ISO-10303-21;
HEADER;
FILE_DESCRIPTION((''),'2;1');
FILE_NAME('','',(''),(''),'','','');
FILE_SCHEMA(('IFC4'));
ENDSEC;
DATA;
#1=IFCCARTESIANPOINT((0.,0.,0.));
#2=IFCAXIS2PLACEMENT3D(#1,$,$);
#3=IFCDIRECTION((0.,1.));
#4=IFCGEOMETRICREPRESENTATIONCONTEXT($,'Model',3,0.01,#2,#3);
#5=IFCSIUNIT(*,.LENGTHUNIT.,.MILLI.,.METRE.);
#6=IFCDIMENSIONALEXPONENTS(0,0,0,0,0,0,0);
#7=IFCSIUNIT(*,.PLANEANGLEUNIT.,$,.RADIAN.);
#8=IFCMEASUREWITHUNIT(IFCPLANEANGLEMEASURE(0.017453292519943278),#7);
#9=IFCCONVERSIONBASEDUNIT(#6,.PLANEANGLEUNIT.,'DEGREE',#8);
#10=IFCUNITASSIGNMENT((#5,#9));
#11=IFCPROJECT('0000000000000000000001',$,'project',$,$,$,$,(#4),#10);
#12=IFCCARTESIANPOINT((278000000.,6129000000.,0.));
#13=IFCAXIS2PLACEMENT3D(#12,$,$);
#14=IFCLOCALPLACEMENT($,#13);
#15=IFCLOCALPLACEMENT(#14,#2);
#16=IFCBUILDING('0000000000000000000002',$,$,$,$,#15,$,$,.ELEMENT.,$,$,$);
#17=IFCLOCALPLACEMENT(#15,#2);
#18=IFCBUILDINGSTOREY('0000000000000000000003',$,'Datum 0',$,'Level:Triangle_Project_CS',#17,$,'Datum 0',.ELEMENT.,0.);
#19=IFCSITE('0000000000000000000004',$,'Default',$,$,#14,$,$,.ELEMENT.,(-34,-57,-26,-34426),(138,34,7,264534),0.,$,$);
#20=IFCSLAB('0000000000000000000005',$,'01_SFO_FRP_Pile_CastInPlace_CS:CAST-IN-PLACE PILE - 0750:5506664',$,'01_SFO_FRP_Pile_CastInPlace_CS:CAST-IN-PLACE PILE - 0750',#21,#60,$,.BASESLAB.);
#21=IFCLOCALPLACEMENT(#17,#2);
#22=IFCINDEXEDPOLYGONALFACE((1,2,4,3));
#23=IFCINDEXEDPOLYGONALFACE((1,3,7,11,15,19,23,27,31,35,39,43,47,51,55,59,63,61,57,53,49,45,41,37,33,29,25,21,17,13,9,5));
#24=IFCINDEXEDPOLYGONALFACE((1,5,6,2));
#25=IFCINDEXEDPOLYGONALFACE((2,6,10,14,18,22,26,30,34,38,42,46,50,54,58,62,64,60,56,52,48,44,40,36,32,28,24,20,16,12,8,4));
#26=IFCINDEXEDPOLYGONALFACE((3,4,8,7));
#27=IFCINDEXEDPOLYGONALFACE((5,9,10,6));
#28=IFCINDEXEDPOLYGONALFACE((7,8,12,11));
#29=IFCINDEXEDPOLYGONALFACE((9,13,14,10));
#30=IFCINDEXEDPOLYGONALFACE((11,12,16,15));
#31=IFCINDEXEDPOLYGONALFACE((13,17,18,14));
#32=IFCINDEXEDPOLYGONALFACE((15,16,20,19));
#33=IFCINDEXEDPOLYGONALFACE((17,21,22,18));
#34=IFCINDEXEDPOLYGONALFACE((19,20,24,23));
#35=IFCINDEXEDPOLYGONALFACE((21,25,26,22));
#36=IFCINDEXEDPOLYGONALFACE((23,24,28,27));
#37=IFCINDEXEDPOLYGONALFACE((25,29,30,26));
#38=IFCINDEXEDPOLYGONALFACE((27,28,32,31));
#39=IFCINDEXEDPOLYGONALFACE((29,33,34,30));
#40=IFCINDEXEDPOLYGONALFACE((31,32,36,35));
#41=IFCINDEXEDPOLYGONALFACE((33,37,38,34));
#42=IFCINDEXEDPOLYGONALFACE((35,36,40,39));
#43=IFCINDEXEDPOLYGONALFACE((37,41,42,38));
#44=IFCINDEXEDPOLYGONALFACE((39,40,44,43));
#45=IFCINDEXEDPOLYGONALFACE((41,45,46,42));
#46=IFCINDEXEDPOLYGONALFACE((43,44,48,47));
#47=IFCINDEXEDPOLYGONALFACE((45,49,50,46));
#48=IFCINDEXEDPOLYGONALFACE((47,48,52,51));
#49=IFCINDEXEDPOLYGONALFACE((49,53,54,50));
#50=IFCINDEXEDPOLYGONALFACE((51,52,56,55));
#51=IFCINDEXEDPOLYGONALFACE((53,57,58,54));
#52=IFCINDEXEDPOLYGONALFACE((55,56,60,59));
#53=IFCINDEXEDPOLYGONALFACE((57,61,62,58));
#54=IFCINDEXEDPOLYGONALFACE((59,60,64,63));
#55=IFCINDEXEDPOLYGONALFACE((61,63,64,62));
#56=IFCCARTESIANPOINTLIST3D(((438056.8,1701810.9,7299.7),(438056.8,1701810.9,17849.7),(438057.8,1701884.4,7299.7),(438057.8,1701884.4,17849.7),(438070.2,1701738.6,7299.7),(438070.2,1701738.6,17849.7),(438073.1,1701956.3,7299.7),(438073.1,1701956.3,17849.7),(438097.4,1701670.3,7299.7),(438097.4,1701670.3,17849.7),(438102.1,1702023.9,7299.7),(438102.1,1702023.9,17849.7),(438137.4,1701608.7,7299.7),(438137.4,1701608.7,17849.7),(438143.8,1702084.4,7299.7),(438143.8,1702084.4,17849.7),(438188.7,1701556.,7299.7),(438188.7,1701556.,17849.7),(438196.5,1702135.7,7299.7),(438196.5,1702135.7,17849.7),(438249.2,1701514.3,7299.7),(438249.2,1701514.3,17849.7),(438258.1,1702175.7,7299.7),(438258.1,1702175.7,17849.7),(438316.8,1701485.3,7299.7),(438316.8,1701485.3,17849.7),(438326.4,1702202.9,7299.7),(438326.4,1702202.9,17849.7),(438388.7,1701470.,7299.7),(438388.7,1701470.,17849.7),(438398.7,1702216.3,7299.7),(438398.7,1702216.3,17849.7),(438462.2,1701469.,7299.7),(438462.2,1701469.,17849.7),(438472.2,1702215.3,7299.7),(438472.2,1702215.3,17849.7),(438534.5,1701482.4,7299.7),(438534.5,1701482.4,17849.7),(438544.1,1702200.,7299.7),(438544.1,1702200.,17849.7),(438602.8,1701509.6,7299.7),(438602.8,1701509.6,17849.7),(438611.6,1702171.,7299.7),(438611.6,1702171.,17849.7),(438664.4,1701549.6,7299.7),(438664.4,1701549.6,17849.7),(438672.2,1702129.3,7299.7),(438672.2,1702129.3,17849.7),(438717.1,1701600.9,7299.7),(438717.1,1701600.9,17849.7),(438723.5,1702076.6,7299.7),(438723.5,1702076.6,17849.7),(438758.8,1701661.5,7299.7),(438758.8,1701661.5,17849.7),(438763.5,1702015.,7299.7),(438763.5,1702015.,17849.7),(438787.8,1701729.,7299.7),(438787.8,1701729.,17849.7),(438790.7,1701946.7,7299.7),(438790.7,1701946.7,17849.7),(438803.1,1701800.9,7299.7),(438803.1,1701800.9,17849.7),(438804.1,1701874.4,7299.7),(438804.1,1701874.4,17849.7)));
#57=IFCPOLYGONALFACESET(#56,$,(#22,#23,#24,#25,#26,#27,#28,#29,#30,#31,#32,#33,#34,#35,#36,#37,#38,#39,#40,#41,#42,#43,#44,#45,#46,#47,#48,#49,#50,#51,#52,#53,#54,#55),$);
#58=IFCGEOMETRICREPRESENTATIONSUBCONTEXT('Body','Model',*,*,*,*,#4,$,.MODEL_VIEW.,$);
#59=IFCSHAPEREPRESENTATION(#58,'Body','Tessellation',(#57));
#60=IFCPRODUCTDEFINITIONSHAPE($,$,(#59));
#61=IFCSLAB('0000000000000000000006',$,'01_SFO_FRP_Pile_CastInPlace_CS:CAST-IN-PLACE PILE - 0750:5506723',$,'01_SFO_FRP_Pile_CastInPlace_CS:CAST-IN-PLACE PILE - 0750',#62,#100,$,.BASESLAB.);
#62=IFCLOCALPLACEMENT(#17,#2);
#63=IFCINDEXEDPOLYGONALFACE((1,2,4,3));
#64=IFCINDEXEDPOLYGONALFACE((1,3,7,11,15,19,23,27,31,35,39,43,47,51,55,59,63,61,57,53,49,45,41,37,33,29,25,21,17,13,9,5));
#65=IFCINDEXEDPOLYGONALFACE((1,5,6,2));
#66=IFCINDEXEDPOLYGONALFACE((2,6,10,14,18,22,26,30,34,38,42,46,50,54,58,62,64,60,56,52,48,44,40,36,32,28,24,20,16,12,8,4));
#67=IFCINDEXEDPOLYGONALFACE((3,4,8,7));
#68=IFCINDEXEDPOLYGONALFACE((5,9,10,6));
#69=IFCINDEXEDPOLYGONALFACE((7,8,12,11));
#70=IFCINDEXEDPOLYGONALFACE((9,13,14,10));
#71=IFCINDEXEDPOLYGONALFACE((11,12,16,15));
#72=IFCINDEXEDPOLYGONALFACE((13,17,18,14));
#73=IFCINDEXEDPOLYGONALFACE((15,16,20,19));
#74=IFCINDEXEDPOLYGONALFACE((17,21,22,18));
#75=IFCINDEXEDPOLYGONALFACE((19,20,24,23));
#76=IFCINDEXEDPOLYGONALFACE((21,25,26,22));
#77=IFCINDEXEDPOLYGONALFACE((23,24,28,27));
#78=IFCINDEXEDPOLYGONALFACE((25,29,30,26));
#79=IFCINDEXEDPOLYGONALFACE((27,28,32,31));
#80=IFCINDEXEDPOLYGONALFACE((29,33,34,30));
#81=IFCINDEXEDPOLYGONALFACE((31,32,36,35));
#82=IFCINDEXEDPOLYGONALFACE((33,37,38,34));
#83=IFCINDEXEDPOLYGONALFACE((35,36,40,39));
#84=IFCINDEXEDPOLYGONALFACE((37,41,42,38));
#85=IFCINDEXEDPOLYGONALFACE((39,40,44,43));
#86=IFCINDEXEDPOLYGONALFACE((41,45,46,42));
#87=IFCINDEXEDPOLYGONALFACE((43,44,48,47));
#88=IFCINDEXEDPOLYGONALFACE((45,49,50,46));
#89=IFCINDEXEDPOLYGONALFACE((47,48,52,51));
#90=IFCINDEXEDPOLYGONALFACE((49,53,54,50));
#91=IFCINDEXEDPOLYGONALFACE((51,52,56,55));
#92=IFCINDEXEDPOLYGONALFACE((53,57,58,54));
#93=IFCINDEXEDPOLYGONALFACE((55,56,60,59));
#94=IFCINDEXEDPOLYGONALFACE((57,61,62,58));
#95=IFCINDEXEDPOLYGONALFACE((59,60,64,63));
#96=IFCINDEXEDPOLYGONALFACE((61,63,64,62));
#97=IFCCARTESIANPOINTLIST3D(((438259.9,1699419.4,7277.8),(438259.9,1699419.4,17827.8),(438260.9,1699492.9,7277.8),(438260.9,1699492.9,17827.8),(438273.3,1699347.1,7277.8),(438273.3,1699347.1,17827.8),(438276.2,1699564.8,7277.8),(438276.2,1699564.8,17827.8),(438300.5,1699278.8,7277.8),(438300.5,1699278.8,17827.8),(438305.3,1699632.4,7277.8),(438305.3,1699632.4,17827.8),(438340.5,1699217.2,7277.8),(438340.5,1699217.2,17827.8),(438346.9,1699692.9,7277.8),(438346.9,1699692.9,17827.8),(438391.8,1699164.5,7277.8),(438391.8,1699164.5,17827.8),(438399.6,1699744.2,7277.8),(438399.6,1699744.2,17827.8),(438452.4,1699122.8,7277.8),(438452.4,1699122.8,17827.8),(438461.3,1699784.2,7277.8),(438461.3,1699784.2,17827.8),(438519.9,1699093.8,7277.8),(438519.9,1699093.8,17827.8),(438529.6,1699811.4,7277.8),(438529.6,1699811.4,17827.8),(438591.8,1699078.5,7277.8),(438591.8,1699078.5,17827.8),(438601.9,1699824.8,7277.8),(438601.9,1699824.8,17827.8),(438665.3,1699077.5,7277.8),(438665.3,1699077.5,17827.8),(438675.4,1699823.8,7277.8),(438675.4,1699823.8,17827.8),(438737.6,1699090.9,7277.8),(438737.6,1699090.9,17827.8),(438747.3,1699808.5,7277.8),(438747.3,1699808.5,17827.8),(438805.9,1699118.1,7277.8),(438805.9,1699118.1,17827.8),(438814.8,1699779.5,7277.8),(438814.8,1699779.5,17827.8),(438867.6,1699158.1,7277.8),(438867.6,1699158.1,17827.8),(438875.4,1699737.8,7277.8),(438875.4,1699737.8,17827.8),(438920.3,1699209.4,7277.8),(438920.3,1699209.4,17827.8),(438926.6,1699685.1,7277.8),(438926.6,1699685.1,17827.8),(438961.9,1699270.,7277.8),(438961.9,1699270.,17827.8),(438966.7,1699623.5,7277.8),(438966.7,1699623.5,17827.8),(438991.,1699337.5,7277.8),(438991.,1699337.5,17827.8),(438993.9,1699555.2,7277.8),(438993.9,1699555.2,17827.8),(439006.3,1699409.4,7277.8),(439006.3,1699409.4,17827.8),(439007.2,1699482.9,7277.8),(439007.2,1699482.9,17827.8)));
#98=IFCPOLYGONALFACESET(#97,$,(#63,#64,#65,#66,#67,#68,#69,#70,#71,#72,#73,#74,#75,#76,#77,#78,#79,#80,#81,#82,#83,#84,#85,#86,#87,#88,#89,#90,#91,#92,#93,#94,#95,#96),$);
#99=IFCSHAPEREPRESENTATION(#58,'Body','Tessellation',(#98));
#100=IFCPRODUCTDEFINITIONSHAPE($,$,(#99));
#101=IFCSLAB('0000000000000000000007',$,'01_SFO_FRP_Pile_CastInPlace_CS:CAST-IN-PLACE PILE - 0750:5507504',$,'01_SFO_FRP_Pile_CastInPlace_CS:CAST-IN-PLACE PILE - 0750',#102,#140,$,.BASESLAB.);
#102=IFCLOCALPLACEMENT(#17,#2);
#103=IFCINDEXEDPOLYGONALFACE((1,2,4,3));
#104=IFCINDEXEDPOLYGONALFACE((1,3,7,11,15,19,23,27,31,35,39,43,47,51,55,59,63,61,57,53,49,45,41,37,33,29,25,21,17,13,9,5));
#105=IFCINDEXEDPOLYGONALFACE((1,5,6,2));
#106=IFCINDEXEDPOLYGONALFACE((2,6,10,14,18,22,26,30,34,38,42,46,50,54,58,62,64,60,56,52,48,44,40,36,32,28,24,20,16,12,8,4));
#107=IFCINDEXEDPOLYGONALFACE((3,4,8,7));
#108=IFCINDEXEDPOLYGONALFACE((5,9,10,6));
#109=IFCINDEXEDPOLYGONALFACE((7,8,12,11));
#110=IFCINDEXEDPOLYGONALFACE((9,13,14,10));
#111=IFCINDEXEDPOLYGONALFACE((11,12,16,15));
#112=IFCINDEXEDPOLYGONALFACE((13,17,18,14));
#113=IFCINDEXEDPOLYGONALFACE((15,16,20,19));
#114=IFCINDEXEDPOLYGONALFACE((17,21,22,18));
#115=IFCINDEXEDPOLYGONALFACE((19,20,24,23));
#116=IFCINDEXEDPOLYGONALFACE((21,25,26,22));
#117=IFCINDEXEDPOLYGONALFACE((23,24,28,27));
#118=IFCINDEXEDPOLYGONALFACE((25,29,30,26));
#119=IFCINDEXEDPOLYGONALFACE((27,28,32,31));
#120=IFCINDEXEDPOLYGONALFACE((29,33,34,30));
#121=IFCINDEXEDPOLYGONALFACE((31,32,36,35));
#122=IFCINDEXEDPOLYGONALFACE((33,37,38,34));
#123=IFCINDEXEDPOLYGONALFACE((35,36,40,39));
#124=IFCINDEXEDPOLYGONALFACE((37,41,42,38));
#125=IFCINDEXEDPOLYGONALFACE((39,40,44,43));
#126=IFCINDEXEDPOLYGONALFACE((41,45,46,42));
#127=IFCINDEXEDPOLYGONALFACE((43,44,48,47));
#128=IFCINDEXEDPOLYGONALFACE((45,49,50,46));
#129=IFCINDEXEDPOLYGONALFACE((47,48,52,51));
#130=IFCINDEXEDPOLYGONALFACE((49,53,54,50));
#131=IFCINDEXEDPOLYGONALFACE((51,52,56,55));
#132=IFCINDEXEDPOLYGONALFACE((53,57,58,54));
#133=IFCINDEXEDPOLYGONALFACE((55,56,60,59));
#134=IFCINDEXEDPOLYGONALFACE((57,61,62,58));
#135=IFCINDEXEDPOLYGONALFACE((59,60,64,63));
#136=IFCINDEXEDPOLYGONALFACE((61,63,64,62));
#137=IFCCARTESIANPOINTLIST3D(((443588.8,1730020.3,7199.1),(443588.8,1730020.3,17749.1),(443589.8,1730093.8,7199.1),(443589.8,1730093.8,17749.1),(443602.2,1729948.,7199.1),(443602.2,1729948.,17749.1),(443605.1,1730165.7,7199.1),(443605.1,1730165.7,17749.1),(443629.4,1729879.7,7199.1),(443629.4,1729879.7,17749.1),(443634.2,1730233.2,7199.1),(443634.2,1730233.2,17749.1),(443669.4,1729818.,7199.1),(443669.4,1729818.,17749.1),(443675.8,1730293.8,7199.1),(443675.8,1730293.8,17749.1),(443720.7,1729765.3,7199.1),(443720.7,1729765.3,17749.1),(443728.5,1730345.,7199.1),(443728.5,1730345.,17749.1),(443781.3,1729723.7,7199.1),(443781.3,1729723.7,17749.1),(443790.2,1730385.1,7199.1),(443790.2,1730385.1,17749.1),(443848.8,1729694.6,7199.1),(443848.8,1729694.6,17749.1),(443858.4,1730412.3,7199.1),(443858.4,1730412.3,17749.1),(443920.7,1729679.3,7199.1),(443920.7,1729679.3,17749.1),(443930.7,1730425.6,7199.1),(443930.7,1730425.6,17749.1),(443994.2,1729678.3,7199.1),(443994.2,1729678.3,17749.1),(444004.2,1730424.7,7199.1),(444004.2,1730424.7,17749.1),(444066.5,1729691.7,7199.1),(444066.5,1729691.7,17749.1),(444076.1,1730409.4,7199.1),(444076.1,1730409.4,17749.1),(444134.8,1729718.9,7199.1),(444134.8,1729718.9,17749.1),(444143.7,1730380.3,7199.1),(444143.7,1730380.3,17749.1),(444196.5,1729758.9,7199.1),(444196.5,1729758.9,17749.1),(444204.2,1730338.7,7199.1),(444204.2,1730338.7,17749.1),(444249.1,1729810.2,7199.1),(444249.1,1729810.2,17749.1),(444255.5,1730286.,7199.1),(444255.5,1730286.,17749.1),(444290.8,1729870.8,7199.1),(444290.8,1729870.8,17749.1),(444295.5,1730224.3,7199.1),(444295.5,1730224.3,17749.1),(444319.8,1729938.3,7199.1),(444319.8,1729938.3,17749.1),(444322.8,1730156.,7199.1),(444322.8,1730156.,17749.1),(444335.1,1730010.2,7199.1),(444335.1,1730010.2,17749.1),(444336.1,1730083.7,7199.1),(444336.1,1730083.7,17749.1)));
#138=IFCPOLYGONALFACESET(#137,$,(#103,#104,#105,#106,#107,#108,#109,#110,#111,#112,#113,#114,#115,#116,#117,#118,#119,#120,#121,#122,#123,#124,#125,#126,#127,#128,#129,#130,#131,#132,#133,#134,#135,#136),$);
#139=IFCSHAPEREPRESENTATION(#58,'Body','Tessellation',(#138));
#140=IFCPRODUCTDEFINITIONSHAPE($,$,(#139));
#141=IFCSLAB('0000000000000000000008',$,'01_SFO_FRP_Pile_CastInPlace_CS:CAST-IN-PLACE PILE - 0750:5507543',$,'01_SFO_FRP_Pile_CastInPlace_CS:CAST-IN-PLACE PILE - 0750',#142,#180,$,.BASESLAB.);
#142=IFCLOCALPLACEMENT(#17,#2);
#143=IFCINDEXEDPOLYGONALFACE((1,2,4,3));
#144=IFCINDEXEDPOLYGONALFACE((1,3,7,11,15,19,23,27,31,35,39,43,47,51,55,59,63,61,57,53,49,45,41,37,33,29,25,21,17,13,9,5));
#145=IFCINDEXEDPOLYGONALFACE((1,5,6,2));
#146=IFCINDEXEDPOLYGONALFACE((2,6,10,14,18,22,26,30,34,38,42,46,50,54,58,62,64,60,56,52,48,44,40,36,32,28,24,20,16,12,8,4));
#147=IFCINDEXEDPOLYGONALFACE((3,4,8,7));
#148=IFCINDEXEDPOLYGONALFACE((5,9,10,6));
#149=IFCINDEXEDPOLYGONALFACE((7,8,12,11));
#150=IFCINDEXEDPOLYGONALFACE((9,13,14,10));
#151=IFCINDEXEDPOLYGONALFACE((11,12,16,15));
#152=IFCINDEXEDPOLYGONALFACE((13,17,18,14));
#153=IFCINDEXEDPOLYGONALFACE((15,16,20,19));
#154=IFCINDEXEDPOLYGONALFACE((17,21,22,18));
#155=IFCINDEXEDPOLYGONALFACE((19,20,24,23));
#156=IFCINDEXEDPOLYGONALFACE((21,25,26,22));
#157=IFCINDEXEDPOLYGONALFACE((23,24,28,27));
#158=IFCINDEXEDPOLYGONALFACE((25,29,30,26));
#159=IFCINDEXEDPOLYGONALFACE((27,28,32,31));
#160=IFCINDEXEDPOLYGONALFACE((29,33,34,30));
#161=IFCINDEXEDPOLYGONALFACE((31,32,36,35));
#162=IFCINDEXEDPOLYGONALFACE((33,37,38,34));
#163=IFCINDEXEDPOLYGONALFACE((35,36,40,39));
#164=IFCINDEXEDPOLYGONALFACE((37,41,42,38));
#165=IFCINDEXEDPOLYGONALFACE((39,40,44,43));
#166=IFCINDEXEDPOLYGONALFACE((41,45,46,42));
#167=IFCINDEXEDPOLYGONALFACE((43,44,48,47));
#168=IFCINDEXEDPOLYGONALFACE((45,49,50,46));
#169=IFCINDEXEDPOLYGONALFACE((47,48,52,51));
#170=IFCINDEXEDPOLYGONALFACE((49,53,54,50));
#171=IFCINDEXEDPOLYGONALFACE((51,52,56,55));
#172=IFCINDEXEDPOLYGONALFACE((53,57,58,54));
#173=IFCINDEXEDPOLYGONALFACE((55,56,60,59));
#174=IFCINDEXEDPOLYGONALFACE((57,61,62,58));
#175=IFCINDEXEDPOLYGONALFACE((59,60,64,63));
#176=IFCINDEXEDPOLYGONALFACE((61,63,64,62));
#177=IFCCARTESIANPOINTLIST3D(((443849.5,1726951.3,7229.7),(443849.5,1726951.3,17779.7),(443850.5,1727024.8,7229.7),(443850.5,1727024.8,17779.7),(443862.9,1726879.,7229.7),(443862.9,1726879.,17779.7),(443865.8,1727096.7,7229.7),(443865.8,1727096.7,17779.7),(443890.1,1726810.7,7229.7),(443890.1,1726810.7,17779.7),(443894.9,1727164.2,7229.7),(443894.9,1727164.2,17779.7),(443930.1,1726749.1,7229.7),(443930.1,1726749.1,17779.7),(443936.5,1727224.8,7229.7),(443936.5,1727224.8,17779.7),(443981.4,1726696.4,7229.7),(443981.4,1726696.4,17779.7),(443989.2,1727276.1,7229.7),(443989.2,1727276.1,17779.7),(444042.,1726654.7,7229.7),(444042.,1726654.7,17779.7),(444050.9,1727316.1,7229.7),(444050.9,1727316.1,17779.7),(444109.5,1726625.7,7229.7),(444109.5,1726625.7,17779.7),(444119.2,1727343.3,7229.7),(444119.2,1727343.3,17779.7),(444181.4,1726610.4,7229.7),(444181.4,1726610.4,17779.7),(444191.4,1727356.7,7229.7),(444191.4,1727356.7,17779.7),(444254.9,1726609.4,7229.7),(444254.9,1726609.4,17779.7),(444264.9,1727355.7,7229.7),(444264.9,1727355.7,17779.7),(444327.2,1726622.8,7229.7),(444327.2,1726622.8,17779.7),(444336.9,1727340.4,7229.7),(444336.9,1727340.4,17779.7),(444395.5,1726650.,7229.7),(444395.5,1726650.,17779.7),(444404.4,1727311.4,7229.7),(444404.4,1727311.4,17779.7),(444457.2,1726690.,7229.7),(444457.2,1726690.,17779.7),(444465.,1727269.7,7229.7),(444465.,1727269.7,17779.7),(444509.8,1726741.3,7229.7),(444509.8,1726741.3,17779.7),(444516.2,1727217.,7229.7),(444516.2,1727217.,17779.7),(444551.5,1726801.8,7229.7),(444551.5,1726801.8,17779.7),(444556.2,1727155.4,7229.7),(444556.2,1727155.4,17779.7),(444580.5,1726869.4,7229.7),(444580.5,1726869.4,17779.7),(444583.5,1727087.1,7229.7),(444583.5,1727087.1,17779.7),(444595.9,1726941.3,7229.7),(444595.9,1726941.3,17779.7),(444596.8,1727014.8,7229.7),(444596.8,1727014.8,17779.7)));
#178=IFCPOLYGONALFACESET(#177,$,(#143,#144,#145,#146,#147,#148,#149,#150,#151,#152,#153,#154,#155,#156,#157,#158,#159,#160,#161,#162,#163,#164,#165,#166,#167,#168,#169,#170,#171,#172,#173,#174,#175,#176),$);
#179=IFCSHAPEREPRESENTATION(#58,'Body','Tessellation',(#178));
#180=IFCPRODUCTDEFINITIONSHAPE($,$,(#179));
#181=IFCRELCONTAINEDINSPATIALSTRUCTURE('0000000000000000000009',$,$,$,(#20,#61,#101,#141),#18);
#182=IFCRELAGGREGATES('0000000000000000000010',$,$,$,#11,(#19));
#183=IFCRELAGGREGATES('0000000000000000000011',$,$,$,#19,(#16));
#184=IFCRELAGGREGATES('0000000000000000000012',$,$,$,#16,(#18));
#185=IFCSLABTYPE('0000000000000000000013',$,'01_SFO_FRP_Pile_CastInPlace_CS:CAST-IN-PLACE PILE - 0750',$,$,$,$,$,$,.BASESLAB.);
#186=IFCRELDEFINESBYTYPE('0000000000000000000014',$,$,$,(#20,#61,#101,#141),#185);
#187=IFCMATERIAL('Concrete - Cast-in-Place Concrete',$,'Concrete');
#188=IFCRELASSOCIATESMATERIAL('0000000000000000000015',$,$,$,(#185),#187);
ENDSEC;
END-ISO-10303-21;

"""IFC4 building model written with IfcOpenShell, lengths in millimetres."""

from ifc_helpers import new_model, entity, si_unit, converted_unit, direction, frame, origin, place, context, subcontext, project, spatial, arc, indexed_curve, outline, extrude, material, type_object, element, save


model = new_model("IFC4")

# Units and contexts
model_context = context("Model", 3, precision=0.01, world=origin(), true_north=direction((0.0, 1.0)))
body_context = subcontext(model_context, "Body", "Model", "MODEL_VIEW")
ifc_project = project(units=[si_unit("LENGTHUNIT", "METRE", prefix="MILLI"), converted_unit("PLANEANGLEUNIT", "DEGREE", entity("IfcPlaneAngleMeasure", 0.017453292519943278), si_unit("PLANEANGLEUNIT", "RADIAN"), dimensions=[0, 0, 0, 0, 0, 0, 0])], contexts=[model_context])

# Site, building, storey
site_placement = place(None, frame((278000000.0, 6129000000.0, 0.0)))
site = spatial("IfcSite", under=ifc_project, at=site_placement, Name="Default", CompositionType="ELEMENT", RefLatitude=(-34, -57, -26, -34426), RefLongitude=(138, 34, 7, 264534), RefElevation=0.0)
building_placement = place(site_placement, origin())
building = spatial("IfcBuilding", under=site, at=building_placement, CompositionType="ELEMENT")
storey_placement = place(building_placement, frame((0.0, 0.0, 0.0)))
storey = spatial("IfcBuildingStorey", under=building, at=storey_placement, Name="Datum 0", ObjectType="Level:Triangle_Project_CS", LongName="Datum 0", CompositionType="ELEMENT", Elevation=0.0)

# Shared definitions
ifc_material_1 = material(Name="Concrete - Cast-in-Place Concrete", Category="Concrete")

# Slabs
slab_type_1 = type_object("IfcSlabType", Name="01_SFO_FRP_Pile_CastInPlace_CS:CAST-IN-PLACE PILE - 0750", PredefinedType="BASESLAB", material=ifc_material_1)
slab_1_placement = place(storey_placement, origin())
element("IfcSlab", 1, at=slab_1_placement, inside=storey, type_object=slab_type_1, Name="01_SFO_FRP_Pile_CastInPlace_CS:CAST-IN-PLACE PILE - 0750:5506664", ObjectType="01_SFO_FRP_Pile_CastInPlace_CS:CAST-IN-PLACE PILE - 0750", PredefinedType="BASESLAB", context=body_context, shape_type="SweptSolid", body=[
    extrude(outline(indexed_curve([(-375.0, 0.0), (0.0, -375.0), (375.0, 0.0), (0.0, 375.0)], segments=[arc(1, 2, 3), arc(3, 4, 1)], self_intersect=False)), frame((438430.4, 1701842.7, 7299.7), z_axis=(0.0, 0.0, 1.0), x_axis=(-0.996411, -0.084646, 0.0)), (0.0, 0.0, 1.0), 10550.0),
])
slab_2_placement = place(storey_placement, origin())
element("IfcSlab", 2, at=slab_2_placement, inside=storey, type_object=slab_type_1, Name="01_SFO_FRP_Pile_CastInPlace_CS:CAST-IN-PLACE PILE - 0750:5506723", ObjectType="01_SFO_FRP_Pile_CastInPlace_CS:CAST-IN-PLACE PILE - 0750", PredefinedType="BASESLAB", context=body_context, shape_type="SweptSolid", body=[
    extrude(outline(indexed_curve([(-375.0, 0.0), (0.0, -375.0), (375.0, 0.0), (0.0, 375.0)], segments=[arc(1, 2, 3), arc(3, 4, 1)], self_intersect=False)), frame((438633.6, 1699451.2, 7277.8), z_axis=(0.0, 0.0, 1.0), x_axis=(-0.996411, -0.084646, 0.0)), (0.0, 0.0, 1.0), 10550.0),
])
slab_3_placement = place(storey_placement, origin())
element("IfcSlab", 3, at=slab_3_placement, inside=storey, type_object=slab_type_1, Name="01_SFO_FRP_Pile_CastInPlace_CS:CAST-IN-PLACE PILE - 0750:5507504", ObjectType="01_SFO_FRP_Pile_CastInPlace_CS:CAST-IN-PLACE PILE - 0750", PredefinedType="BASESLAB", context=body_context, shape_type="SweptSolid", body=[
    extrude(outline(indexed_curve([(-375.0, 0.0), (0.0, -375.0), (375.0, 0.0), (0.0, 375.0)], segments=[arc(1, 2, 3), arc(3, 4, 1)], self_intersect=False)), frame((443962.5, 1730052.0, 7199.1), z_axis=(0.0, 0.0, 1.0), x_axis=(0.996411, 0.084646, 0.0)), (0.0, 0.0, 1.0), 10550.0),
])
slab_4_placement = place(storey_placement, origin())
element("IfcSlab", 4, at=slab_4_placement, inside=storey, type_object=slab_type_1, Name="01_SFO_FRP_Pile_CastInPlace_CS:CAST-IN-PLACE PILE - 0750:5507543", ObjectType="01_SFO_FRP_Pile_CastInPlace_CS:CAST-IN-PLACE PILE - 0750", PredefinedType="BASESLAB", context=body_context, shape_type="SweptSolid", body=[
    extrude(outline(indexed_curve([(-375.0, 0.0), (0.0, -375.0), (375.0, 0.0), (0.0, 375.0)], segments=[arc(1, 2, 3), arc(3, 4, 1)], self_intersect=False)), frame((444223.2, 1726983.0, 7229.7), z_axis=(0.0, 0.0, 1.0), x_axis=(0.996411, 0.084646, 0.0)), (0.0, 0.0, 1.0), 10550.0),
])

save(model, "model.ifc")
